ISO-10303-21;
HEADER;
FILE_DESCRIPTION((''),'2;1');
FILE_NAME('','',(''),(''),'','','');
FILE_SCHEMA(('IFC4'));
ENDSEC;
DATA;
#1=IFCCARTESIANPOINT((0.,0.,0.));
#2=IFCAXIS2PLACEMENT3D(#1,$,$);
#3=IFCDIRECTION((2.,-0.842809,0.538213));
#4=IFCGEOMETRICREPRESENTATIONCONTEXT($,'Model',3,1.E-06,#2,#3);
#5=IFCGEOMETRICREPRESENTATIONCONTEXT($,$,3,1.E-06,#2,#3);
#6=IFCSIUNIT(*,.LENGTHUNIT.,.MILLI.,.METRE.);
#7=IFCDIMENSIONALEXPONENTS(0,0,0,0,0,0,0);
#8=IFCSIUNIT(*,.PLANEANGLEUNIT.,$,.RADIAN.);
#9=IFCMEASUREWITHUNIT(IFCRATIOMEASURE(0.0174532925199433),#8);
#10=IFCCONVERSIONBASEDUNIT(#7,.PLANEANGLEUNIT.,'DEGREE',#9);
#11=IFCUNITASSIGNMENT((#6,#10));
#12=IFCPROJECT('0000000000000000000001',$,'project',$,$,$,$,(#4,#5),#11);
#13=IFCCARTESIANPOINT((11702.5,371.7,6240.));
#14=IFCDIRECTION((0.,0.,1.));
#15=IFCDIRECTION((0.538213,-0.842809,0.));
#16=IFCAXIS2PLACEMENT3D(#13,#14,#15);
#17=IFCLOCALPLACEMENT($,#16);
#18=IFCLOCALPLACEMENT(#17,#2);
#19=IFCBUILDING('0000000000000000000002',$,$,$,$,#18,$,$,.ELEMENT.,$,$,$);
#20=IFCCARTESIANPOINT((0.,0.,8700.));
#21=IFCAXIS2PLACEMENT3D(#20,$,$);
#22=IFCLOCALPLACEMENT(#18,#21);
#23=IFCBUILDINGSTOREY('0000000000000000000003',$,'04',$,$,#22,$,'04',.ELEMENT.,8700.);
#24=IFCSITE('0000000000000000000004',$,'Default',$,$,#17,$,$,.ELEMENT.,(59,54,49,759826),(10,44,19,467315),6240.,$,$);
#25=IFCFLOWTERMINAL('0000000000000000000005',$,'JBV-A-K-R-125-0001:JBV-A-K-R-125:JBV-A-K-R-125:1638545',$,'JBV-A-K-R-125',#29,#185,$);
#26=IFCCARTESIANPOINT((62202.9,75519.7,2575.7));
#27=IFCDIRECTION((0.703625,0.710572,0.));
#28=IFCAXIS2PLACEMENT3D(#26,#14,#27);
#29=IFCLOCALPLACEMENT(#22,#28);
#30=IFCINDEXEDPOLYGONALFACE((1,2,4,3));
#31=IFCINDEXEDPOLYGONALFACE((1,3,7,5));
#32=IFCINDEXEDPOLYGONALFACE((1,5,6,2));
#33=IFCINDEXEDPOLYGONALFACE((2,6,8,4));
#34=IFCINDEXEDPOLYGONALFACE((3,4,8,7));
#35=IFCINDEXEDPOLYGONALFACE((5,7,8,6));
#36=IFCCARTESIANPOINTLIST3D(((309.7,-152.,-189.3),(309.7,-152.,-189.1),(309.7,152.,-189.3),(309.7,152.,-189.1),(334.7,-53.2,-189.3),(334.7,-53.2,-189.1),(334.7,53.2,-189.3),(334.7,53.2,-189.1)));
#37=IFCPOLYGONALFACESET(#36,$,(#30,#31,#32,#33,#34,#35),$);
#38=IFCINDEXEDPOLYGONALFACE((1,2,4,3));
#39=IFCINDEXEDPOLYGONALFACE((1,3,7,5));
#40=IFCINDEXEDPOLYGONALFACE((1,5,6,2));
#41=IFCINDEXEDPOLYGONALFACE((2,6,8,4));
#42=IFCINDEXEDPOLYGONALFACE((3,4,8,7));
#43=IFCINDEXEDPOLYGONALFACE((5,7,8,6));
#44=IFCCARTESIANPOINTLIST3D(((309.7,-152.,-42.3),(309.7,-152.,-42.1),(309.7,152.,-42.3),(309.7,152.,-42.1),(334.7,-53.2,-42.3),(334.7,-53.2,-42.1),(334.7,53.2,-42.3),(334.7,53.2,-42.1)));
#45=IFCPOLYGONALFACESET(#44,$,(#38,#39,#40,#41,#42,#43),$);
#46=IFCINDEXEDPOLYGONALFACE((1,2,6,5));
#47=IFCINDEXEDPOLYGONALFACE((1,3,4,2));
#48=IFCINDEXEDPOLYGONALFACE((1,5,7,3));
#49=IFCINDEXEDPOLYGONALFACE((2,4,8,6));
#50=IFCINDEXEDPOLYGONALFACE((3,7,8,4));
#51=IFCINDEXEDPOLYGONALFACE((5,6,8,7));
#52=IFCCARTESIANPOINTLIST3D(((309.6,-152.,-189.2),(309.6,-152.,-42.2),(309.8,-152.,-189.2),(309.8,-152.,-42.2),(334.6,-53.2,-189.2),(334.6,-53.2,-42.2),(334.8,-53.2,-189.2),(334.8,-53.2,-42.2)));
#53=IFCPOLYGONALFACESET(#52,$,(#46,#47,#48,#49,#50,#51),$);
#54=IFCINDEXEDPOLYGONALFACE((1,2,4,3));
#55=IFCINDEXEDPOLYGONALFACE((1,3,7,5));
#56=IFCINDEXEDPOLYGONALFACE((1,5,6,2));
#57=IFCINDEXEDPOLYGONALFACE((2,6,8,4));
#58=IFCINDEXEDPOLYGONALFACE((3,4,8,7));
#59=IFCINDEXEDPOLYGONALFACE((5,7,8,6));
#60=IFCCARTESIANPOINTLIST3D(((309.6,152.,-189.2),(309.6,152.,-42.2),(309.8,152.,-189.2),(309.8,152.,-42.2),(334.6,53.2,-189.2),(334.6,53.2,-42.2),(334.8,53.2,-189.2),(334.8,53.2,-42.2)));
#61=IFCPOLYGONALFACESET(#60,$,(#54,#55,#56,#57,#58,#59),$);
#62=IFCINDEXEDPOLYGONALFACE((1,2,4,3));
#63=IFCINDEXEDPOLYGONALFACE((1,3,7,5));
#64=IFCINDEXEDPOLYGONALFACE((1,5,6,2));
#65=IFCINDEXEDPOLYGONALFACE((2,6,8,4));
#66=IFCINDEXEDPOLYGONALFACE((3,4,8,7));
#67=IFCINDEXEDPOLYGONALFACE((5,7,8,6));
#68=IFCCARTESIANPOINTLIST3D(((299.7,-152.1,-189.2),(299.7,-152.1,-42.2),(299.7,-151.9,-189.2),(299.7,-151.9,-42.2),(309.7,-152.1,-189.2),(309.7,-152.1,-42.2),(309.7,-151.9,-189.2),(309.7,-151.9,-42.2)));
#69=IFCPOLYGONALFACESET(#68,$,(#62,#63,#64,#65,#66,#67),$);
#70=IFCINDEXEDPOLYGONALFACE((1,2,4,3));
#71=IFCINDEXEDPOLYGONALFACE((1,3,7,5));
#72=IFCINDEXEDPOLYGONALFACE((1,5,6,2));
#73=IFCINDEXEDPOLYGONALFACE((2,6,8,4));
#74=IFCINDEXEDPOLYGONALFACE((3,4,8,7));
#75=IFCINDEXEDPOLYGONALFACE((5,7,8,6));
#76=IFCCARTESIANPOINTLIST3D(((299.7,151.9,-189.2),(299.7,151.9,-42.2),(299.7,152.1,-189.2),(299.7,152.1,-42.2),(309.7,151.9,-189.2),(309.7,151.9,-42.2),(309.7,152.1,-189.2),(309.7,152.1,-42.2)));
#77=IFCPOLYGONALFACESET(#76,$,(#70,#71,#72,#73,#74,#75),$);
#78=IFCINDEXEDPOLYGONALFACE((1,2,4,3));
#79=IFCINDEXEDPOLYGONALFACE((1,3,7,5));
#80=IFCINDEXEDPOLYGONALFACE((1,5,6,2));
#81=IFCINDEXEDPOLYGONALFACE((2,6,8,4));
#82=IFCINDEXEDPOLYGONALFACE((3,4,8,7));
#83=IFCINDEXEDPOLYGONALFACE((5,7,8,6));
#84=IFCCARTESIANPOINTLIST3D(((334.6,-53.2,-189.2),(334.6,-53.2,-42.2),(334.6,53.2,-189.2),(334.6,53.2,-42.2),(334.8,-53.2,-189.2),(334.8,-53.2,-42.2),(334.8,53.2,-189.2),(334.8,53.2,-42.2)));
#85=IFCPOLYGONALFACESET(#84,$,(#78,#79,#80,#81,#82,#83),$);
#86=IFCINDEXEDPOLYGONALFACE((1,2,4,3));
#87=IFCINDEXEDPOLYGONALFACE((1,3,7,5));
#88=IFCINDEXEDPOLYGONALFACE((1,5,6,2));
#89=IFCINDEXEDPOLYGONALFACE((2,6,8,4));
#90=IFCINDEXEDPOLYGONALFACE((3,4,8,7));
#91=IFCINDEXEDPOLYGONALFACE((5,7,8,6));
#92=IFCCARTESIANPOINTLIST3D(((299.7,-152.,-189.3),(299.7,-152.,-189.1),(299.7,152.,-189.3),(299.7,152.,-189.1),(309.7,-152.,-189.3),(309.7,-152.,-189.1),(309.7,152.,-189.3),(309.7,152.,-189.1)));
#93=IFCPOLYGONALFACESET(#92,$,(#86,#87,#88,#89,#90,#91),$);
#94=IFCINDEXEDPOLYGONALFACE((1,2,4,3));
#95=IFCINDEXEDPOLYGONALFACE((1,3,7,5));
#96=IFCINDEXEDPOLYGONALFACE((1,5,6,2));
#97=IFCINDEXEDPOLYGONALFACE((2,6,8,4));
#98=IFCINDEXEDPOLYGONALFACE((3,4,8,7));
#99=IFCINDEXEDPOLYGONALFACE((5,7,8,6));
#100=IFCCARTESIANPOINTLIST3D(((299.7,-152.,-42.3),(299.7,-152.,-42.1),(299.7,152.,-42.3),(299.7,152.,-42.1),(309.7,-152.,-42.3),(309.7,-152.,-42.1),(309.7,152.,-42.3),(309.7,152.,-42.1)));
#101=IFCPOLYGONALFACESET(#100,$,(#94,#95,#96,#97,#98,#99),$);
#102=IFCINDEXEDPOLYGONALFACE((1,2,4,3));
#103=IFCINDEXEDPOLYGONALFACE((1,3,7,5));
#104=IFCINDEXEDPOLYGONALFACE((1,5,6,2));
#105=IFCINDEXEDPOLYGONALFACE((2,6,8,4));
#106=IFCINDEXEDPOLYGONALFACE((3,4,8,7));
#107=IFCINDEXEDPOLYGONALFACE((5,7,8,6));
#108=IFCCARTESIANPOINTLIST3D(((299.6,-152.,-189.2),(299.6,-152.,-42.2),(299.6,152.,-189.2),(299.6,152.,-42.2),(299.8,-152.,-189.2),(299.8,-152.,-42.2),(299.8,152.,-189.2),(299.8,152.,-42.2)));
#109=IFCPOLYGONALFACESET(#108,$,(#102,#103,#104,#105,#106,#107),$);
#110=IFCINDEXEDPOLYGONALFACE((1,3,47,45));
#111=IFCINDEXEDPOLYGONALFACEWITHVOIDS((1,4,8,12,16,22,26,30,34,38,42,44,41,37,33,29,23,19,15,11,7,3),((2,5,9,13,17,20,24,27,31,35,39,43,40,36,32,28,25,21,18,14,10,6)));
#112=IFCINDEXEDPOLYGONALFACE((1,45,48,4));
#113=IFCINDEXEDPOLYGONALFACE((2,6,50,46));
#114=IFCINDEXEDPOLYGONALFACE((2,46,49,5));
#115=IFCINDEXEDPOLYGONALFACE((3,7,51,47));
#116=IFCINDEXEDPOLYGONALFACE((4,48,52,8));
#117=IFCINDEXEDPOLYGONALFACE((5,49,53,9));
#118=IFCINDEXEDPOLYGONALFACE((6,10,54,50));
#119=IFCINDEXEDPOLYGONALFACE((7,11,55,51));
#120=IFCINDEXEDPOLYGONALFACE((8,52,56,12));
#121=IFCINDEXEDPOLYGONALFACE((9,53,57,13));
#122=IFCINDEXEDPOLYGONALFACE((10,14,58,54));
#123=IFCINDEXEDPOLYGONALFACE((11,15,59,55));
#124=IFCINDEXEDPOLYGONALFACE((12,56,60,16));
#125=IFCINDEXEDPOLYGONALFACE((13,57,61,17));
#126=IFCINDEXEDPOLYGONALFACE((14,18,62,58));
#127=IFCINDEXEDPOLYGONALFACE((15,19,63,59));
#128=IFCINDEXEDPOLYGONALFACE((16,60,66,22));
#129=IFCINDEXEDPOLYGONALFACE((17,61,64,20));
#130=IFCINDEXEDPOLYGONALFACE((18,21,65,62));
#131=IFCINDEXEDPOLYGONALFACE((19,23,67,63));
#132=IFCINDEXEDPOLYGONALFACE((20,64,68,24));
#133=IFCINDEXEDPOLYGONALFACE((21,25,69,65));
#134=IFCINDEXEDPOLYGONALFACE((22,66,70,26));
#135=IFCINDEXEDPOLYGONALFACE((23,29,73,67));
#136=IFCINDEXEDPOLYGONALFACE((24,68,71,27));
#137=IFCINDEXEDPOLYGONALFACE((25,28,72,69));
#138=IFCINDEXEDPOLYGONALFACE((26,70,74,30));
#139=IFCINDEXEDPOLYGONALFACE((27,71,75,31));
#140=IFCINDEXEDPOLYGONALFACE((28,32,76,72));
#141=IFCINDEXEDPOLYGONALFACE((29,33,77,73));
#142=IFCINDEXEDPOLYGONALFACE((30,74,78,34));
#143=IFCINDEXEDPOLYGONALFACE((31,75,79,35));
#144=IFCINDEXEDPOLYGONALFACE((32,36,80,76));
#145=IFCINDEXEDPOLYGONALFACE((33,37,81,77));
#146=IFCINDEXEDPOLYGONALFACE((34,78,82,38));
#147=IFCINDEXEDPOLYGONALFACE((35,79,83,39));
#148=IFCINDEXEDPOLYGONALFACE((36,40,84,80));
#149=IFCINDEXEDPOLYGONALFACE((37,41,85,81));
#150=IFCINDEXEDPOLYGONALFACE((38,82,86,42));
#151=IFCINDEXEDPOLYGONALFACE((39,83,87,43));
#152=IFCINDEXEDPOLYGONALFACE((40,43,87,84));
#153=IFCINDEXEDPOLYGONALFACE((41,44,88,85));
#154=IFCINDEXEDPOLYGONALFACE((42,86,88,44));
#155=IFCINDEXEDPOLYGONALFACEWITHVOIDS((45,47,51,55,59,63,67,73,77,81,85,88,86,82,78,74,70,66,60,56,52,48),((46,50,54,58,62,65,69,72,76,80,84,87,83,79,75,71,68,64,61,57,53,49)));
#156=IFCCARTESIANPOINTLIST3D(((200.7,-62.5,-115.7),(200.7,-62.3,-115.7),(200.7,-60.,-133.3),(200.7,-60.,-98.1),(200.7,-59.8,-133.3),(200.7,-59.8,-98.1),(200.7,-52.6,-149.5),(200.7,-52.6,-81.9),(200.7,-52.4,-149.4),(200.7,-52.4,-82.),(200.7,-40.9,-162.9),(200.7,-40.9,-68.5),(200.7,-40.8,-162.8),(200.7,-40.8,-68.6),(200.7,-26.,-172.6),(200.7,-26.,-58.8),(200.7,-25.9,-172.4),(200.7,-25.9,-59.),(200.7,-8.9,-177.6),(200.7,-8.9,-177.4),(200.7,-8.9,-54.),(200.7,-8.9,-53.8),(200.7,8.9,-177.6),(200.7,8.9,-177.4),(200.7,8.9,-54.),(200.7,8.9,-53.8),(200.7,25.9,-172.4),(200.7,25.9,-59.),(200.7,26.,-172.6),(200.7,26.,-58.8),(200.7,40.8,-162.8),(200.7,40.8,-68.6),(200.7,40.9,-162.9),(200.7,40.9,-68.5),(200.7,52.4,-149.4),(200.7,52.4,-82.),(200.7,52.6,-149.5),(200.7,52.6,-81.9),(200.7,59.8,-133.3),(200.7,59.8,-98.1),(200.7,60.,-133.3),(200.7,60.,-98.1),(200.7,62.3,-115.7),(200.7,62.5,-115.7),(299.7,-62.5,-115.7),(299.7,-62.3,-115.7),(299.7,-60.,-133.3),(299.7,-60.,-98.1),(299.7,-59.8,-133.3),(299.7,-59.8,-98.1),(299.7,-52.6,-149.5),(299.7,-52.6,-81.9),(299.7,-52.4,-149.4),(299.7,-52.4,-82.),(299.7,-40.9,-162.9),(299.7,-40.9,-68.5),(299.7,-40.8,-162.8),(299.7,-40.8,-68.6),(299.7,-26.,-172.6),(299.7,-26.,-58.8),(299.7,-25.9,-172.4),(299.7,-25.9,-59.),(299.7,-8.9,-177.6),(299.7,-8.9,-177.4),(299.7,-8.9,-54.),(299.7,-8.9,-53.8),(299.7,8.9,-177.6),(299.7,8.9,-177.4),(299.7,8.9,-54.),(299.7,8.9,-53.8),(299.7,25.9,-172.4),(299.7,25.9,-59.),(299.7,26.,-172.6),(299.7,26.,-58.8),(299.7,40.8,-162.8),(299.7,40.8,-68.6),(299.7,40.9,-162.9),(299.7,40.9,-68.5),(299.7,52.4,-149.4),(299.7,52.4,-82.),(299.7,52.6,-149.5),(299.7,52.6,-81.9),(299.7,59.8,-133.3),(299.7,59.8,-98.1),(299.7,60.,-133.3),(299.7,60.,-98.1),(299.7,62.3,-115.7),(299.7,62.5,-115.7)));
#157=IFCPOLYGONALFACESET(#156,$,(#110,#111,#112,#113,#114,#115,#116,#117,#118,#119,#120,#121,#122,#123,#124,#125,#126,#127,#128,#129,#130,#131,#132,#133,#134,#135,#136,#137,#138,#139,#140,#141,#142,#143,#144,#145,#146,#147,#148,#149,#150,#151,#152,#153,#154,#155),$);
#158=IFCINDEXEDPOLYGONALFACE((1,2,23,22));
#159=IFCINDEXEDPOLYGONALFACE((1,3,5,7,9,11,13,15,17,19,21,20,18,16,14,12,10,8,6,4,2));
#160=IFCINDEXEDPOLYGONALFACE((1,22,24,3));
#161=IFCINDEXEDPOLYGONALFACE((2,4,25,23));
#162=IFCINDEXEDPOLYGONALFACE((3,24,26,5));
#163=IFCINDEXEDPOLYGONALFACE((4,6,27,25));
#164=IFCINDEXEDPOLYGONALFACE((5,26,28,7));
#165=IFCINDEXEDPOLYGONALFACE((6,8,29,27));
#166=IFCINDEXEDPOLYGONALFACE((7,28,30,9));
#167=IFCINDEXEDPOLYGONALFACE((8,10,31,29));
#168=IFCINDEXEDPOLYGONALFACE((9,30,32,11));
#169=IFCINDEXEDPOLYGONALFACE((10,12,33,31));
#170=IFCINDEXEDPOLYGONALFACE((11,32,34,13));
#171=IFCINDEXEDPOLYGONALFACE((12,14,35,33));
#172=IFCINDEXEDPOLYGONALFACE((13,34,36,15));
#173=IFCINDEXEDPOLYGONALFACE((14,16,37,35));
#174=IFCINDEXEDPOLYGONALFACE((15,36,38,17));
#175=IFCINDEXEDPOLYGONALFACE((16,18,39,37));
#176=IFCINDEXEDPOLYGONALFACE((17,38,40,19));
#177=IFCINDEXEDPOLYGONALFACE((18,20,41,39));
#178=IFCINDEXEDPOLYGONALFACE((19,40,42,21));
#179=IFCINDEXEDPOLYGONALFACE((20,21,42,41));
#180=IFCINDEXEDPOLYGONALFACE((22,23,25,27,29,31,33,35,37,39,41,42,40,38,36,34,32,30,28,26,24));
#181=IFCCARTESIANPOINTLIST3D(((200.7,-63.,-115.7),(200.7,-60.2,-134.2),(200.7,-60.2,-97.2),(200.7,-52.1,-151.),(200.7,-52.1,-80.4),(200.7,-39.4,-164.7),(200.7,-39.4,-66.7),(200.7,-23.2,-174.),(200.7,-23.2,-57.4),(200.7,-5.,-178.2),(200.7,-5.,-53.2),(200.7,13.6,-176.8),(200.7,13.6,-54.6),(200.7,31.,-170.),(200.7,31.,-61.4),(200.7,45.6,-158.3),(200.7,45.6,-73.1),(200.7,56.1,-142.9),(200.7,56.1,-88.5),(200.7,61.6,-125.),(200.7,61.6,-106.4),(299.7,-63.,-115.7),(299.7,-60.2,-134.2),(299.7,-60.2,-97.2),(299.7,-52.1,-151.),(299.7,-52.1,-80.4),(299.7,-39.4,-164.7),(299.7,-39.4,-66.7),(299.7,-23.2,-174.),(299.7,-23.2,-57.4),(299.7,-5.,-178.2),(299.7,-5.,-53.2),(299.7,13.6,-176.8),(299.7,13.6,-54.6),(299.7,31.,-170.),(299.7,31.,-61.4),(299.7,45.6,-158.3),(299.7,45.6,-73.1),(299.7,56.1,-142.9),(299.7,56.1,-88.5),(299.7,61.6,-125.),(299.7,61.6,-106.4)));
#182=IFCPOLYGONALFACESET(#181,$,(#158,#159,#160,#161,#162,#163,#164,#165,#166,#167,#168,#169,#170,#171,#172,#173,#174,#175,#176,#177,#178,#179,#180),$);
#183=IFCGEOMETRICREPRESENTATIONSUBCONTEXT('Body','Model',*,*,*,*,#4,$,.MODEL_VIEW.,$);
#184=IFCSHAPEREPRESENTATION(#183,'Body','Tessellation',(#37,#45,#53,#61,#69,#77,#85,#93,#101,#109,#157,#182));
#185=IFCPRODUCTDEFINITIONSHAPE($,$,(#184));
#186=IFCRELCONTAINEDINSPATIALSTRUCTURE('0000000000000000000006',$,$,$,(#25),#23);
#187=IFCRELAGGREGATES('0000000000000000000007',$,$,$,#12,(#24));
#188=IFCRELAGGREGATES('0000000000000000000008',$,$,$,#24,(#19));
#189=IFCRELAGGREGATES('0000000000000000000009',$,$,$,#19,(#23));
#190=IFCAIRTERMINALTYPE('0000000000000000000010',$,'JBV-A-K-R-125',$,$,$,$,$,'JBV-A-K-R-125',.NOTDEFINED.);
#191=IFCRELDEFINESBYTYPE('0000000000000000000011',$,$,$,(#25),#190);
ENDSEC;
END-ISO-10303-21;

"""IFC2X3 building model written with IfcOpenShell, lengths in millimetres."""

from ifc_helpers import new_model, entity, si_unit, converted_unit, direction, frame, frame_2d, origin, origin_2d_with_axis, place, context, subcontext, project, spatial, polyline, circle_curve, parameter, trimmed, segment, composite_curve, rectangle, circle, outline, extrude, source, transform, mapped, type_object, type_shapes, element, save


model = new_model("IFC2X3")

# Units and contexts
model_context = context("Model", 3, precision=1e-06, world=origin(), true_north=direction((2.0, -0.842809, 0.538213)))
context_of_model = context(None, 3, precision=1e-06, world=origin(), true_north=direction((2.0, -0.842809, 0.538213)))
body_context = subcontext(model_context, "Body", "Model", "MODEL_VIEW")
ifc_project = project(units=[si_unit("LENGTHUNIT", "METRE", prefix="MILLI"), converted_unit("PLANEANGLEUNIT", "DEGREE", entity("IfcRatioMeasure", 0.0174532925199433), si_unit("PLANEANGLEUNIT", "RADIAN"), dimensions=[0, 0, 0, 0, 0, 0, 0])], contexts=[model_context, context_of_model])

# Site, building, storey
site_placement = place(None, frame((11702.5, 371.7, 6240.0), z_axis=(0.0, 0.0, 1.0), x_axis=(0.538213, -0.842809, 0.0)))
site = spatial("IfcSite", under=ifc_project, at=site_placement, Name="Default", CompositionType="ELEMENT", RefLatitude=(59, 54, 49, 759826), RefLongitude=(10, 44, 19, 467315), RefElevation=6240.0)
building_placement = place(site_placement, origin())
building = spatial("IfcBuilding", under=site, at=building_placement, CompositionType="ELEMENT")
storey_placement = place(building_placement, frame((0.0, 0.0, 8700.0)))
storey = spatial("IfcBuildingStorey", under=building, at=storey_placement, Name="04", LongName="04", CompositionType="ELEMENT", Elevation=8700.0)

# Flow terminal
air_terminal_type_1 = type_object("IfcAirTerminalType", Name="JBV-A-K-R-125", ElementType="JBV-A-K-R-125", PredefinedType="NOTDEFINED")
shared_shape_1 = source(origin(), body_context, "Body", "SweptSolid", [
    extrude(outline(polyline([(-150.4, -25.2), (-48.5, -25.2), (54.6, 0.9), (144.3, 49.4), (-150.4, -25.2)])), frame((322.2, 0.0, -189.3), z_axis=(0.0, 0.0, 1.0), x_axis=(0.245305, 0.969446, 0.0)), (0.0, 0.0, 1.0), 0.2),
    extrude(outline(polyline([(-150.4, -25.2), (-48.5, -25.2), (54.6, 0.9), (144.3, 49.4), (-150.4, -25.2)])), frame((322.2, 0.0, -42.3), z_axis=(0.0, 0.0, 1.0), x_axis=(0.245305, 0.969446, 0.0)), (0.0, 0.0, 1.0), 0.2),
    extrude(rectangle(XDim=101.9, YDim=0.2, at=frame_2d((0.0, 0.0), x_axis=(1.0, 0.0))), frame((322.2, -102.6, -189.2), z_axis=(0.0, 0.0, 1.0), x_axis=(-0.245305, -0.969446, 0.0)), (0.0, 0.0, 1.0), 147.0),
    extrude(rectangle(XDim=101.9, YDim=0.2, at=frame_2d((0.0, 0.0), x_axis=(1.0, 0.0))), frame((322.2, 102.6, -189.2), z_axis=(0.0, 0.0, 1.0), x_axis=(-0.245305, 0.969446, 0.0)), (0.0, 0.0, 1.0), 147.0),
    extrude(rectangle(XDim=10.0, YDim=0.2, at=frame_2d((0.0, 0.0), x_axis=(1.0, 0.0))), frame((304.7, -152.0, -189.2), z_axis=(0.0, 0.0, 1.0), x_axis=(-1.0, 0.0, 0.0)), (0.0, 0.0, 1.0), 147.0),
    extrude(rectangle(XDim=10.0, YDim=0.2, at=frame_2d((0.0, 0.0), x_axis=(1.0, 0.0))), frame((304.7, 152.0, -189.2), z_axis=(0.0, 0.0, 1.0), x_axis=(-1.0, 0.0, 0.0)), (0.0, 0.0, 1.0), 147.0),
    extrude(rectangle(XDim=106.4, YDim=0.2, at=frame_2d((0.0, 0.0), x_axis=(1.0, 0.0))), frame((334.7, 0.0, -189.2), z_axis=(0.0, 0.0, 1.0), x_axis=(0.0, -1.0, 0.0)), (0.0, 0.0, 1.0), 147.0),
    extrude(rectangle(XDim=10.0, YDim=304.0, at=frame_2d((0.0, 0.0), x_axis=(1.0, 0.0))), frame((304.7, 0.0, -189.3)), (0.0, 0.0, 1.0), 0.2),
    extrude(rectangle(XDim=10.0, YDim=304.0, at=frame_2d((0.0, 0.0), x_axis=(1.0, 0.0))), frame((304.7, 0.0, -42.3)), (0.0, 0.0, 1.0), 0.2),
    extrude(rectangle(XDim=304.0, YDim=0.2, at=frame_2d((0.0, 0.0), x_axis=(1.0, 0.0))), frame((299.7, 0.0, -189.2), z_axis=(0.0, 0.0, 1.0), x_axis=(0.0, -1.0, 0.0)), (0.0, 0.0, 1.0), 147.0),
    extrude(outline(composite_curve([segment(trimmed(circle_curve(origin_2d_with_axis(), 62.5), [parameter(0.0)], [parameter(180.0)], True, "PARAMETER"), True, "CONTINUOUS"), segment(trimmed(circle_curve(origin_2d_with_axis(), 62.5), [parameter(180.0)], [parameter(0.0)], True, "PARAMETER"), True, "CONTINUOUS")], self_intersect=False), holes=[composite_curve([segment(trimmed(circle_curve(origin_2d_with_axis(), 62.3), [parameter(180.0)], [parameter(360.0)], True, "PARAMETER"), False, "CONTINUOUS"), segment(trimmed(circle_curve(origin_2d_with_axis(), 62.3), [parameter(0.0)], [parameter(180.0)], True, "PARAMETER"), False, "CONTINUOUS")], self_intersect=False)]), frame((200.7, 0.0, -115.7), z_axis=(1.0, 0.0, 0.0), x_axis=(0.0, -1.0, 0.0)), (0.0, 0.0, 1.0), 99.0),
    extrude(circle(Radius=62.6, at=frame_2d((0.0, 0.0), x_axis=(1.0, 0.0))), frame((200.7, -0.3, -115.7), z_axis=(1.0, 0.0, 0.0), x_axis=(0.0, -1.0, 0.0)), (0.0, 0.0, 1.0), 99.0),
])
type_shapes(air_terminal_type_1, [shared_shape_1])
for number, where, z_axis, x_axis, name in (
    (1, (62202.9, 75519.7, 2575.7), (0.0, 0.0, 1.0), (0.703625, 0.710572, 0.0), "JBV-A-K-R-125-0001:JBV-A-K-R-125:JBV-A-K-R-125:1638545"),
):
    element("IfcFlowTerminal", number, at=place(storey_placement, frame(where, z_axis=z_axis, x_axis=x_axis)), inside=storey, type_object=air_terminal_type_1, Name=name, ObjectType="JBV-A-K-R-125", context=body_context, shape_type="MappedRepresentation", body=[
        mapped(shared_shape_1, transform((0.0, 0.0, 0.0), scale=1.0)),
    ])

save(model, "model.ifc")
